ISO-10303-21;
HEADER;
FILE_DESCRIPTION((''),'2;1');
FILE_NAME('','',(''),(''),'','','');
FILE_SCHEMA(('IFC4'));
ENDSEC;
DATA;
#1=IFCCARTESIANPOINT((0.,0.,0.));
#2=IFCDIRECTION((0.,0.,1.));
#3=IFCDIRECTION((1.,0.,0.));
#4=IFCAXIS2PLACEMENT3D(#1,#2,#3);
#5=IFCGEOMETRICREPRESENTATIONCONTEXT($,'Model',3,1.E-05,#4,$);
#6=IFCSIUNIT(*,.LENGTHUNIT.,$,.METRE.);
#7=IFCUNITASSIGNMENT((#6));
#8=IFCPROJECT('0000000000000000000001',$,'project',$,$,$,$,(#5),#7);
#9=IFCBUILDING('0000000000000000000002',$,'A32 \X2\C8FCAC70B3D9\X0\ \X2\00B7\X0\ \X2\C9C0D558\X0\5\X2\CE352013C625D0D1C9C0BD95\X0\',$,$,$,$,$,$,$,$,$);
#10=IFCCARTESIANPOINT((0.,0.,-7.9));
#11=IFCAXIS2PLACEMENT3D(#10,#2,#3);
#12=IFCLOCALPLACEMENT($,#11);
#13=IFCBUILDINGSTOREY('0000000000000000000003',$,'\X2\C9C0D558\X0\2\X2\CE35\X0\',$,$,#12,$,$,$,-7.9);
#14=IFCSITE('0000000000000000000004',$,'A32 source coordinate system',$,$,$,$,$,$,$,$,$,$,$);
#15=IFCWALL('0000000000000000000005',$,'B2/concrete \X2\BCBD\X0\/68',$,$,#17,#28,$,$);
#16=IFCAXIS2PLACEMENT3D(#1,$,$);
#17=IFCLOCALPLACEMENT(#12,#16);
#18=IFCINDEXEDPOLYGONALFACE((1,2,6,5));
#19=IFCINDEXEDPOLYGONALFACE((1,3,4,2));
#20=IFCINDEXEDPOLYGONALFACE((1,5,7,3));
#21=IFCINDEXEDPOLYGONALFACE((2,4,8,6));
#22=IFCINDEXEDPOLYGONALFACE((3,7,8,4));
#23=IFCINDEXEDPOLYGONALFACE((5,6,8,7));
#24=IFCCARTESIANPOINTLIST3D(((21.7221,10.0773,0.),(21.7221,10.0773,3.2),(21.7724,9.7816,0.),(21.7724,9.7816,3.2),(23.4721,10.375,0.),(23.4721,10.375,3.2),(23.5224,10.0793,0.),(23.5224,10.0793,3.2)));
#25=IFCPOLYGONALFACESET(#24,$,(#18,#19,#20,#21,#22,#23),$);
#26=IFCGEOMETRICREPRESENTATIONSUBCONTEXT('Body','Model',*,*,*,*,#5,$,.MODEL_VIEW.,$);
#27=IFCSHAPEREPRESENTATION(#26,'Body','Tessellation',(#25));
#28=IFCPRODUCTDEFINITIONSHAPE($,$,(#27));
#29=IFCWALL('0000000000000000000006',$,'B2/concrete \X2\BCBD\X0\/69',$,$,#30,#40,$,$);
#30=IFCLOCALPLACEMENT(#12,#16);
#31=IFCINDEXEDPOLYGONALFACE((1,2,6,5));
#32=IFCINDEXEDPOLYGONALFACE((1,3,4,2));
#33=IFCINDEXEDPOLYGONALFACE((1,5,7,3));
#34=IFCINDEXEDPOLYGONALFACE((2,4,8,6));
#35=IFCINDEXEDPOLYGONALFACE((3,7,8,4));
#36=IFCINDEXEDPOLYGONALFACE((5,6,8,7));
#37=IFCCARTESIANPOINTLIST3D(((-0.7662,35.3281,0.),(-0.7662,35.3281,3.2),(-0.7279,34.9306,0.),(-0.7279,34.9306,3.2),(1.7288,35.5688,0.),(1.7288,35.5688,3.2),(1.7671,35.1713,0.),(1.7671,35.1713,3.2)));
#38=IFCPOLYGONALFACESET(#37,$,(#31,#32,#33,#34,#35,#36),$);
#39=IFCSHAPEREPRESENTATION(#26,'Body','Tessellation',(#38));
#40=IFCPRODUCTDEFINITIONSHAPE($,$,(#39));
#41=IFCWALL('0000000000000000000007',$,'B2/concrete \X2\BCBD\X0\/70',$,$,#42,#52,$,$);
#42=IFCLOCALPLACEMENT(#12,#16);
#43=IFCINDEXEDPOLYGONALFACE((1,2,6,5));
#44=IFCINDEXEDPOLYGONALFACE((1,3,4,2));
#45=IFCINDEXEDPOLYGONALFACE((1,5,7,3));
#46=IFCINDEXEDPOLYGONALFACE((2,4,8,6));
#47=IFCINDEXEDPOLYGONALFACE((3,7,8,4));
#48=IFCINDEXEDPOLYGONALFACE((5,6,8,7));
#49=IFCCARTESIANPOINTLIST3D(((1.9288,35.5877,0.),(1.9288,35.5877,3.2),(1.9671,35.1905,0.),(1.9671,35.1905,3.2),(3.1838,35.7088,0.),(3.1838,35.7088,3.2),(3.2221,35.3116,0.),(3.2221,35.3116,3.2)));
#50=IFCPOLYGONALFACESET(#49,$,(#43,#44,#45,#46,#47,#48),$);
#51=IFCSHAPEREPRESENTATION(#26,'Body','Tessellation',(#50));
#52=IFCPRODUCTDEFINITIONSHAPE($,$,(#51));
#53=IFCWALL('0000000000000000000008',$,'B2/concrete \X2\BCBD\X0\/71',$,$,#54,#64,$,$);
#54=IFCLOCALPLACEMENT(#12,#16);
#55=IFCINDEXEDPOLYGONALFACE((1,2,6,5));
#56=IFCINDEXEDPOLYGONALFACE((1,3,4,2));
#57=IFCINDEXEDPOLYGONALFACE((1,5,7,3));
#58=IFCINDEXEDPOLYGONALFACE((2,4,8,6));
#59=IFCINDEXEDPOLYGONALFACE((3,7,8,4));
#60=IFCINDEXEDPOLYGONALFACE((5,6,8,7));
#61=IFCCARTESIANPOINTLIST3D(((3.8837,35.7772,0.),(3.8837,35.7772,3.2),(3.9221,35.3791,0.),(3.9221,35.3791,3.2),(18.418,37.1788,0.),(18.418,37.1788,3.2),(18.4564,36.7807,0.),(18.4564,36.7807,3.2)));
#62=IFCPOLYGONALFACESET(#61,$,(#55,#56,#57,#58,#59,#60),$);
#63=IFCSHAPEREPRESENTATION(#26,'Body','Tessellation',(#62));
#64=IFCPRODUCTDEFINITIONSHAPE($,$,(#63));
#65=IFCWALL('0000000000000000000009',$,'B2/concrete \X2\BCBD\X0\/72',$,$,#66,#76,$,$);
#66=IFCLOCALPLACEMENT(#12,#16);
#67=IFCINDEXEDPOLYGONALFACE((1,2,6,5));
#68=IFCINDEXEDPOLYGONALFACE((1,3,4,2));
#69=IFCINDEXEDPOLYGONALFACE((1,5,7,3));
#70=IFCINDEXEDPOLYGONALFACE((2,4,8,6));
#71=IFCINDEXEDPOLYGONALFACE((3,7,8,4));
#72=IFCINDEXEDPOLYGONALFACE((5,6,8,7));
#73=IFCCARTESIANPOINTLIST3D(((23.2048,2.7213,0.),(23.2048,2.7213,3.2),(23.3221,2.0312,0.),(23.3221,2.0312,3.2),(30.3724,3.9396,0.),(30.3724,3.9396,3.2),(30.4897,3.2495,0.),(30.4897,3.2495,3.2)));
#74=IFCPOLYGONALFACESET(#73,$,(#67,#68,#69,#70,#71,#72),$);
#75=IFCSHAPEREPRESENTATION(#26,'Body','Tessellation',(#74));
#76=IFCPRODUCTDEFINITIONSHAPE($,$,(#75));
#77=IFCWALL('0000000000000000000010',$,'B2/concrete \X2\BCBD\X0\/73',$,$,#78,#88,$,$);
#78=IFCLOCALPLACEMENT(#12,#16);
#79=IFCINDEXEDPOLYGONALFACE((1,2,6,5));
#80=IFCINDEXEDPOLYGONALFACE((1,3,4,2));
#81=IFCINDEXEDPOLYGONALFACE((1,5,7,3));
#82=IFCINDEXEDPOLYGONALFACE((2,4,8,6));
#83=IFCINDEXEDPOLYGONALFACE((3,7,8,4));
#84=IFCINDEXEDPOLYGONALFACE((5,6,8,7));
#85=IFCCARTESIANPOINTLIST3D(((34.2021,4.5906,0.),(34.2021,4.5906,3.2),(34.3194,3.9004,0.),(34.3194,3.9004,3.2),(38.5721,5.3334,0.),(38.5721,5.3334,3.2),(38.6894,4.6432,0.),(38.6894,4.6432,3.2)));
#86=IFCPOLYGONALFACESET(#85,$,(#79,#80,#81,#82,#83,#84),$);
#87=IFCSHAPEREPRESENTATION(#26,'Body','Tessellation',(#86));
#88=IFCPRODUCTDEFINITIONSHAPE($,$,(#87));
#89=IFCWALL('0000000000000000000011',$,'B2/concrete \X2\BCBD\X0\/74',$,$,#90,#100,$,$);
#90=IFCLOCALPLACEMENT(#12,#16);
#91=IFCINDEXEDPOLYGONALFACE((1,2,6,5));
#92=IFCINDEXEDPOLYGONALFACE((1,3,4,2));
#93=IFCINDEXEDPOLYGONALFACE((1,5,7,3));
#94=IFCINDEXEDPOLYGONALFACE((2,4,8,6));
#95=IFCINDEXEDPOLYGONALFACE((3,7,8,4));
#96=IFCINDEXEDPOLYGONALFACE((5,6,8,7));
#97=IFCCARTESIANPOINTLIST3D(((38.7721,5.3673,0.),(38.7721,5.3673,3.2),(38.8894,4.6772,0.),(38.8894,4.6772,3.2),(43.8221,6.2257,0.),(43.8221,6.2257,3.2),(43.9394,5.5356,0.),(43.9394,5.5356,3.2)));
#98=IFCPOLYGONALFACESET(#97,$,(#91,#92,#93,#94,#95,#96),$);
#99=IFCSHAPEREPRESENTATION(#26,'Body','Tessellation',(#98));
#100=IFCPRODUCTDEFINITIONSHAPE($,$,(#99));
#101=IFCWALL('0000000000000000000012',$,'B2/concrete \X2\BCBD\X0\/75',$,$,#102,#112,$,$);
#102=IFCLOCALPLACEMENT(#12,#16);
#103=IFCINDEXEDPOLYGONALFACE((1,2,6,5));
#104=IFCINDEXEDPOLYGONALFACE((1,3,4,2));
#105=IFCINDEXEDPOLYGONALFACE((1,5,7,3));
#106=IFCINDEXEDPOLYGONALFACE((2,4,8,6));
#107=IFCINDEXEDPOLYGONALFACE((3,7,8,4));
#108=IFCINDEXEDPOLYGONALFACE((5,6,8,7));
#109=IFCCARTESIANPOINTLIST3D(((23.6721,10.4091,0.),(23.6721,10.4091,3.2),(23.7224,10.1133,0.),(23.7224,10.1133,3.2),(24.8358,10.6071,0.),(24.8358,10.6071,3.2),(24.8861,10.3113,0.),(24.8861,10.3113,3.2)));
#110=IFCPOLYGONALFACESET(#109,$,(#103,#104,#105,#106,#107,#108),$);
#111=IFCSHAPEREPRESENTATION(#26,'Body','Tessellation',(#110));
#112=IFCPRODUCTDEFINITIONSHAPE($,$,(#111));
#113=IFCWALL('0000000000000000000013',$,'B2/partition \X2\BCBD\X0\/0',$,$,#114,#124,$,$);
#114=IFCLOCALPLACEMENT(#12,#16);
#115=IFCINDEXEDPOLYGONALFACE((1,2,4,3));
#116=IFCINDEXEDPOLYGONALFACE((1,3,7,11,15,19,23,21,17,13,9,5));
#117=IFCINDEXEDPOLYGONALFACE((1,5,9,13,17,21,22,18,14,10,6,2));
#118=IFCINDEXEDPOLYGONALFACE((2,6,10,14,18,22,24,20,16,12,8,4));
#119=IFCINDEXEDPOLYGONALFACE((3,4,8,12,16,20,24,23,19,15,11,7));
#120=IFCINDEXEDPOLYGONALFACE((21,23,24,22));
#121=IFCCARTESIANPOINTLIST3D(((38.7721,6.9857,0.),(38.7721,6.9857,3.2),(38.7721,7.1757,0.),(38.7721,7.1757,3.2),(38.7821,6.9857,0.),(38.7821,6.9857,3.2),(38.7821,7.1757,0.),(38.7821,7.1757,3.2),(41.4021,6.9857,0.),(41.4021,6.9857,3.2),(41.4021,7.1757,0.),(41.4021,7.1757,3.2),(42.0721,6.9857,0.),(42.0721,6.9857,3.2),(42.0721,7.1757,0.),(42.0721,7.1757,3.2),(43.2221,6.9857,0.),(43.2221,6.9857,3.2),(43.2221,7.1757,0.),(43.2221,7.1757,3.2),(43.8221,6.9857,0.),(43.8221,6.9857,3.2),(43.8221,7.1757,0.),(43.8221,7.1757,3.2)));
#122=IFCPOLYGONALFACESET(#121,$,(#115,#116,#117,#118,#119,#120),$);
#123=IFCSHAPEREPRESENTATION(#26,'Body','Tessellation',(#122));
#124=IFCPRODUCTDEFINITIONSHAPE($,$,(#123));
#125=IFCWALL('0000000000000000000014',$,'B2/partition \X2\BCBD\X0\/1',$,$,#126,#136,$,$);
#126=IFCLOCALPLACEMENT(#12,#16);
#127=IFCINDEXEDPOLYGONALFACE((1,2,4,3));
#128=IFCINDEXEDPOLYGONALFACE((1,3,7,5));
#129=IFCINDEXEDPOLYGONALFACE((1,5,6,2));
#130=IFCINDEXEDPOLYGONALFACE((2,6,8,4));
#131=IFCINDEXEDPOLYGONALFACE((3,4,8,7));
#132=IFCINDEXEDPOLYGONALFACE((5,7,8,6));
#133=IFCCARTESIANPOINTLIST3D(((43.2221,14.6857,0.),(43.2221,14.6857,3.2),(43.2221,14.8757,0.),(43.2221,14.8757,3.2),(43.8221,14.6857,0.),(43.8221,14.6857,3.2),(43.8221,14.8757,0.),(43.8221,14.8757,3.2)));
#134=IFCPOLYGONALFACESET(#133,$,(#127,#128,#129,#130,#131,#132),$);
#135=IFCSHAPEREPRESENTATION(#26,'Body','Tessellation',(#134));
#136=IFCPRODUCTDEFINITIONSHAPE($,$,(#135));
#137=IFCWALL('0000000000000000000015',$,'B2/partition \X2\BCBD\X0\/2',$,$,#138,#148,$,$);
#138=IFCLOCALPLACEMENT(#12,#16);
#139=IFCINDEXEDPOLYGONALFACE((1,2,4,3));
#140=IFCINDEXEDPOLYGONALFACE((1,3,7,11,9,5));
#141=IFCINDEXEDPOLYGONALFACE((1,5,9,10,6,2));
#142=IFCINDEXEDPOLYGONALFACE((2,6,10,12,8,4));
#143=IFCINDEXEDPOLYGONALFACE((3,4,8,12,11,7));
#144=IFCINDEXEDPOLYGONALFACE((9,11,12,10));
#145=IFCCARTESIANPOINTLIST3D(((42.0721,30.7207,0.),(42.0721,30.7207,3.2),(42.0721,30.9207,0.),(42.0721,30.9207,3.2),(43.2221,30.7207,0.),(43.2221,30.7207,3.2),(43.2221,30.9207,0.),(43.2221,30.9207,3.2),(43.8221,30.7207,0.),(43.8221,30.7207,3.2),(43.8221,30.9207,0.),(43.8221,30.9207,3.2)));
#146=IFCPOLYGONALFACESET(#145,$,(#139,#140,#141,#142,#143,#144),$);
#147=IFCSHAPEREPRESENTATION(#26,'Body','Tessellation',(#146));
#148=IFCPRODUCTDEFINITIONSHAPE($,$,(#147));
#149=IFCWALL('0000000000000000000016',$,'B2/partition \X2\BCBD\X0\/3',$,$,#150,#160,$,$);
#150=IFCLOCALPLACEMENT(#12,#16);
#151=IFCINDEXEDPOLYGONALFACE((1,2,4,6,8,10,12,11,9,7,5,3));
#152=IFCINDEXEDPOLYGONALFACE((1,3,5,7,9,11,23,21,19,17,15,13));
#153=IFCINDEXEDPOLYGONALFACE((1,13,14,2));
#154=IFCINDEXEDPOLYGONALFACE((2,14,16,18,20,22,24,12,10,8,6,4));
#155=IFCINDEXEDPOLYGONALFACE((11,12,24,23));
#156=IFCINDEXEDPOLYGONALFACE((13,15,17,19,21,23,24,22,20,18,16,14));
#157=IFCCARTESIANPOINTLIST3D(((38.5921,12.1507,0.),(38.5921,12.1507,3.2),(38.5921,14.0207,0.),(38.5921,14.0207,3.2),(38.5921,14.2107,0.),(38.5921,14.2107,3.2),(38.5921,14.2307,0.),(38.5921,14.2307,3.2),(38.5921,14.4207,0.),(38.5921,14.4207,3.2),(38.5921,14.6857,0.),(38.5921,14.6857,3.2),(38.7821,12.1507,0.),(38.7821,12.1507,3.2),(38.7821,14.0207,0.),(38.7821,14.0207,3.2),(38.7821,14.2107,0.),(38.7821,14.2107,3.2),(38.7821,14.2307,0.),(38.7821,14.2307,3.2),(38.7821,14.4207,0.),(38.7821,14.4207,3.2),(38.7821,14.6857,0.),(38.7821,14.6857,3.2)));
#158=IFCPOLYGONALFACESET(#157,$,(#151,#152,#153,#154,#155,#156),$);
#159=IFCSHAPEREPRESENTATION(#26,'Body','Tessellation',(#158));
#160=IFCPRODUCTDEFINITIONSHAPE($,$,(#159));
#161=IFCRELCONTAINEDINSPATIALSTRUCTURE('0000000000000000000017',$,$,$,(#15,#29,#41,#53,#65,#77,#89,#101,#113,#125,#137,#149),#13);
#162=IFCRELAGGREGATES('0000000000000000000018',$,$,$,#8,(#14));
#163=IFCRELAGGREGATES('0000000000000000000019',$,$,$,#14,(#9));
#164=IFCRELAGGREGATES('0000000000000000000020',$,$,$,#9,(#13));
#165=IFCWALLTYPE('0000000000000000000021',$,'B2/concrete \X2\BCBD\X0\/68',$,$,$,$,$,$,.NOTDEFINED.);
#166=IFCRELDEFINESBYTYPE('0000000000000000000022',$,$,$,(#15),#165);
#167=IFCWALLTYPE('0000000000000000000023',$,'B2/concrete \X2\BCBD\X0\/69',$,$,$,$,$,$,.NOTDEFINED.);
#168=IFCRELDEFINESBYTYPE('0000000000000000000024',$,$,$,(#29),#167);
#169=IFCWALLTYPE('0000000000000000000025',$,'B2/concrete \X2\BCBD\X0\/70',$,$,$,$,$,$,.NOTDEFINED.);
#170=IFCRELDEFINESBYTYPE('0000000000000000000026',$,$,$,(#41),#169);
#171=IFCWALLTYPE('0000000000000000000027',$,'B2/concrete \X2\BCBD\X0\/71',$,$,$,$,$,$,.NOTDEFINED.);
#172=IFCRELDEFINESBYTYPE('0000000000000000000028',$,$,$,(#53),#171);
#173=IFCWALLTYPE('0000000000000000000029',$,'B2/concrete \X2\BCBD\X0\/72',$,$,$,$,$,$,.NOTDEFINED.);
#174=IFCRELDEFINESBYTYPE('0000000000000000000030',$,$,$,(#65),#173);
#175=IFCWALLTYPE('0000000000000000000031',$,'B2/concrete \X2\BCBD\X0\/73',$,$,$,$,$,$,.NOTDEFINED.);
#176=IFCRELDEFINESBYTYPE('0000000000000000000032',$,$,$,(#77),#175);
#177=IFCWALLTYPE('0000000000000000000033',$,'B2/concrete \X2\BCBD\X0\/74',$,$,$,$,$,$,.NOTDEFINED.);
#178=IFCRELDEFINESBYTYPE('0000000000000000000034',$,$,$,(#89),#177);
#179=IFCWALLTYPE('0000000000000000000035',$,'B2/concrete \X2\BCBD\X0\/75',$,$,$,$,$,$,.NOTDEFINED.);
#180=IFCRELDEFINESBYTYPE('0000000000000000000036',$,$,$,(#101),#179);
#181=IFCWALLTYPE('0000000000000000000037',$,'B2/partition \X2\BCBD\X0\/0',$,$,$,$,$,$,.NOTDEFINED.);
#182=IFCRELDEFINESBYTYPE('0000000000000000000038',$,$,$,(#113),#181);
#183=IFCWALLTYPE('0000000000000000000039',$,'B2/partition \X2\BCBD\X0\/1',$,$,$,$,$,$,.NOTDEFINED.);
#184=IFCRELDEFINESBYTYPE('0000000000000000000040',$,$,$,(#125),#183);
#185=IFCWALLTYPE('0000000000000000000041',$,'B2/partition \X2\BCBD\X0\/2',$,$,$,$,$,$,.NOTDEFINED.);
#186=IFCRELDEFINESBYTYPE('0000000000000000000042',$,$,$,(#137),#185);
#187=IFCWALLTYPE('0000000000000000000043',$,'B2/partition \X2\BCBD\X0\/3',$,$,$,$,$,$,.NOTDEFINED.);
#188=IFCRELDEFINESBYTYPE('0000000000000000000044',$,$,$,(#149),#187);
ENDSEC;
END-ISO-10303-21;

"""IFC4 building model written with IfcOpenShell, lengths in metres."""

from ifc_helpers import new_model, si_unit, frame, origin, origin_with_axes, place, context, subcontext, project, spatial, polyline, outline, extrude, source, transform, mapped, type_object, type_shapes, element, save


model = new_model("IFC4")

# Units and contexts
model_context = context("Model", 3, precision=1e-05, world=origin_with_axes())
body_context = subcontext(model_context, "Body", "Model", "MODEL_VIEW")
ifc_project = project(units=[si_unit("LENGTHUNIT", "METRE")], contexts=[model_context])

# Site, building, storey
site = spatial("IfcSite", under=ifc_project, Name="A32 source coordinate system")
building = spatial("IfcBuilding", under=site, Name="A32 주거동 · 지하5층–옥탑지붕")
storey_placement = place(None, frame((0.0, 0.0, -7.9), z_axis=(0.0, 0.0, 1.0), x_axis=(1.0, 0.0, 0.0)))
storey = spatial("IfcBuildingStorey", under=building, at=storey_placement, Name="지하2층", Elevation=-7.9)

# Walls
wall_type_1 = type_object("IfcWallType", Name="B2/concrete 벽/68", PredefinedType="NOTDEFINED")
shared_shape_1 = source(origin(), body_context, "Body", "SweptSolid", [
    extrude(outline(polyline([(21.7221, 10.0773), (23.4721, 10.375), (23.5224, 10.0793), (21.7724, 9.7816), (21.7221, 10.0773)])), origin(), (0.0, 0.0, 1.0), 3.2),
])
type_shapes(wall_type_1, [shared_shape_1])
wall_1_placement = place(storey_placement, origin_with_axes())
element("IfcWall", 1, at=wall_1_placement, inside=storey, type_object=wall_type_1, Name="B2/concrete 벽/68", context=body_context, shape_type="MappedRepresentation", body=[
    mapped(shared_shape_1, transform((0.0, 0.0, 0.0), scale=1.0)),
])
wall_type_2 = type_object("IfcWallType", Name="B2/concrete 벽/69", PredefinedType="NOTDEFINED")
shared_shape_2 = source(origin(), body_context, "Body", "SweptSolid", [
    extrude(outline(polyline([(-0.7662, 35.3281), (1.7288, 35.5688), (1.7671, 35.1713), (-0.7279, 34.9306), (-0.7662, 35.3281)])), origin(), (0.0, 0.0, 1.0), 3.2),
])
type_shapes(wall_type_2, [shared_shape_2])
wall_2_placement = place(storey_placement, origin_with_axes())
element("IfcWall", 2, at=wall_2_placement, inside=storey, type_object=wall_type_2, Name="B2/concrete 벽/69", context=body_context, shape_type="MappedRepresentation", body=[
    mapped(shared_shape_2, transform((0.0, 0.0, 0.0), scale=1.0)),
])
wall_type_3 = type_object("IfcWallType", Name="B2/concrete 벽/70", PredefinedType="NOTDEFINED")
shared_shape_3 = source(origin(), body_context, "Body", "SweptSolid", [
    extrude(outline(polyline([(1.9288, 35.5877), (3.1838, 35.7088), (3.2221, 35.3116), (1.9671, 35.1905), (1.9288, 35.5877)])), origin(), (0.0, 0.0, 1.0), 3.2),
])
type_shapes(wall_type_3, [shared_shape_3])
wall_3_placement = place(storey_placement, origin_with_axes())
element("IfcWall", 3, at=wall_3_placement, inside=storey, type_object=wall_type_3, Name="B2/concrete 벽/70", context=body_context, shape_type="MappedRepresentation", body=[
    mapped(shared_shape_3, transform((0.0, 0.0, 0.0), scale=1.0)),
])
wall_type_4 = type_object("IfcWallType", Name="B2/concrete 벽/71", PredefinedType="NOTDEFINED")
shared_shape_4 = source(origin(), body_context, "Body", "SweptSolid", [
    extrude(outline(polyline([(3.9221, 35.3791), (3.8837, 35.7772), (18.418, 37.1788), (18.4564, 36.7807), (3.9221, 35.3791)])), origin(), (0.0, 0.0, 1.0), 3.2),
])
type_shapes(wall_type_4, [shared_shape_4])
wall_4_placement = place(storey_placement, origin_with_axes())
element("IfcWall", 4, at=wall_4_placement, inside=storey, type_object=wall_type_4, Name="B2/concrete 벽/71", context=body_context, shape_type="MappedRepresentation", body=[
    mapped(shared_shape_4, transform((0.0, 0.0, 0.0), scale=1.0)),
])
wall_type_5 = type_object("IfcWallType", Name="B2/concrete 벽/72", PredefinedType="NOTDEFINED")
shared_shape_5 = source(origin(), body_context, "Body", "SweptSolid", [
    extrude(outline(polyline([(30.4897, 3.2495), (23.3221, 2.0312), (23.2048, 2.7213), (30.3724, 3.9396), (30.4897, 3.2495)])), origin(), (0.0, 0.0, 1.0), 3.2),
])
type_shapes(wall_type_5, [shared_shape_5])
wall_5_placement = place(storey_placement, origin_with_axes())
element("IfcWall", 5, at=wall_5_placement, inside=storey, type_object=wall_type_5, Name="B2/concrete 벽/72", context=body_context, shape_type="MappedRepresentation", body=[
    mapped(shared_shape_5, transform((0.0, 0.0, 0.0), scale=1.0)),
])
wall_type_6 = type_object("IfcWallType", Name="B2/concrete 벽/73", PredefinedType="NOTDEFINED")
shared_shape_6 = source(origin(), body_context, "Body", "SweptSolid", [
    extrude(outline(polyline([(38.5721, 5.3334), (38.6894, 4.6432), (34.3194, 3.9004), (34.2021, 4.5906), (38.5721, 5.3334)])), origin(), (0.0, 0.0, 1.0), 3.2),
])
type_shapes(wall_type_6, [shared_shape_6])
wall_6_placement = place(storey_placement, origin_with_axes())
element("IfcWall", 6, at=wall_6_placement, inside=storey, type_object=wall_type_6, Name="B2/concrete 벽/73", context=body_context, shape_type="MappedRepresentation", body=[
    mapped(shared_shape_6, transform((0.0, 0.0, 0.0), scale=1.0)),
])
wall_type_7 = type_object("IfcWallType", Name="B2/concrete 벽/74", PredefinedType="NOTDEFINED")
shared_shape_7 = source(origin(), body_context, "Body", "SweptSolid", [
    extrude(outline(polyline([(38.7721, 5.3673), (43.8221, 6.2257), (43.9394, 5.5356), (38.8894, 4.6772), (38.7721, 5.3673)])), origin(), (0.0, 0.0, 1.0), 3.2),
])
type_shapes(wall_type_7, [shared_shape_7])
wall_7_placement = place(storey_placement, origin_with_axes())
element("IfcWall", 7, at=wall_7_placement, inside=storey, type_object=wall_type_7, Name="B2/concrete 벽/74", context=body_context, shape_type="MappedRepresentation", body=[
    mapped(shared_shape_7, transform((0.0, 0.0, 0.0), scale=1.0)),
])
wall_type_8 = type_object("IfcWallType", Name="B2/concrete 벽/75", PredefinedType="NOTDEFINED")
shared_shape_8 = source(origin(), body_context, "Body", "SweptSolid", [
    extrude(outline(polyline([(24.8358, 10.6071), (24.8861, 10.3113), (23.7224, 10.1133), (23.6721, 10.4091), (24.8358, 10.6071)])), origin(), (0.0, 0.0, 1.0), 3.2),
])
type_shapes(wall_type_8, [shared_shape_8])
wall_8_placement = place(storey_placement, origin_with_axes())
element("IfcWall", 8, at=wall_8_placement, inside=storey, type_object=wall_type_8, Name="B2/concrete 벽/75", context=body_context, shape_type="MappedRepresentation", body=[
    mapped(shared_shape_8, transform((0.0, 0.0, 0.0), scale=1.0)),
])
wall_type_9 = type_object("IfcWallType", Name="B2/partition 벽/0", PredefinedType="NOTDEFINED")
shared_shape_9 = source(origin(), body_context, "Body", "SweptSolid", [
    extrude(outline(polyline([(38.7721, 7.1757), (38.7821, 7.1757), (41.4021, 7.1757), (42.0721, 7.1757), (43.2221, 7.1757), (43.8221, 7.1757), (43.8221, 6.9857), (43.2221, 6.9857), (42.0721, 6.9857), (41.4021, 6.9857), (38.7821, 6.9857), (38.7721, 6.9857), (38.7721, 7.1757)])), origin(), (0.0, 0.0, 1.0), 3.2),
])
type_shapes(wall_type_9, [shared_shape_9])
wall_9_placement = place(storey_placement, origin_with_axes())
element("IfcWall", 9, at=wall_9_placement, inside=storey, type_object=wall_type_9, Name="B2/partition 벽/0", context=body_context, shape_type="MappedRepresentation", body=[
    mapped(shared_shape_9, transform((0.0, 0.0, 0.0), scale=1.0)),
])
wall_type_10 = type_object("IfcWallType", Name="B2/partition 벽/1", PredefinedType="NOTDEFINED")
shared_shape_10 = source(origin(), body_context, "Body", "SweptSolid", [
    extrude(outline(polyline([(43.8221, 14.8757), (43.8221, 14.6857), (43.2221, 14.6857), (43.2221, 14.8757), (43.8221, 14.8757)])), origin(), (0.0, 0.0, 1.0), 3.2),
])
type_shapes(wall_type_10, [shared_shape_10])
wall_10_placement = place(storey_placement, origin_with_axes())
element("IfcWall", 10, at=wall_10_placement, inside=storey, type_object=wall_type_10, Name="B2/partition 벽/1", context=body_context, shape_type="MappedRepresentation", body=[
    mapped(shared_shape_10, transform((0.0, 0.0, 0.0), scale=1.0)),
])
wall_type_11 = type_object("IfcWallType", Name="B2/partition 벽/2", PredefinedType="NOTDEFINED")
shared_shape_11 = source(origin(), body_context, "Body", "SweptSolid", [
    extrude(outline(polyline([(42.0721, 30.7207), (42.0721, 30.9207), (43.2221, 30.9207), (43.8221, 30.9207), (43.8221, 30.7207), (43.2221, 30.7207), (42.0721, 30.7207)])), origin(), (0.0, 0.0, 1.0), 3.2),
])
type_shapes(wall_type_11, [shared_shape_11])
wall_11_placement = place(storey_placement, origin_with_axes())
element("IfcWall", 11, at=wall_11_placement, inside=storey, type_object=wall_type_11, Name="B2/partition 벽/2", context=body_context, shape_type="MappedRepresentation", body=[
    mapped(shared_shape_11, transform((0.0, 0.0, 0.0), scale=1.0)),
])
wall_type_12 = type_object("IfcWallType", Name="B2/partition 벽/3", PredefinedType="NOTDEFINED")
shared_shape_12 = source(origin(), body_context, "Body", "SweptSolid", [
    extrude(outline(polyline([(38.5921, 14.4207), (38.5921, 14.6857), (38.7821, 14.6857), (38.7821, 14.4207), (38.7821, 14.2307), (38.7821, 14.2107), (38.7821, 14.0207), (38.7821, 12.1507), (38.5921, 12.1507), (38.5921, 14.0207), (38.5921, 14.2107), (38.5921, 14.2307), (38.5921, 14.4207)])), origin(), (0.0, 0.0, 1.0), 3.2),
])
type_shapes(wall_type_12, [shared_shape_12])
wall_12_placement = place(storey_placement, origin_with_axes())
element("IfcWall", 12, at=wall_12_placement, inside=storey, type_object=wall_type_12, Name="B2/partition 벽/3", context=body_context, shape_type="MappedRepresentation", body=[
    mapped(shared_shape_12, transform((0.0, 0.0, 0.0), scale=1.0)),
])

save(model, "model.ifc")
